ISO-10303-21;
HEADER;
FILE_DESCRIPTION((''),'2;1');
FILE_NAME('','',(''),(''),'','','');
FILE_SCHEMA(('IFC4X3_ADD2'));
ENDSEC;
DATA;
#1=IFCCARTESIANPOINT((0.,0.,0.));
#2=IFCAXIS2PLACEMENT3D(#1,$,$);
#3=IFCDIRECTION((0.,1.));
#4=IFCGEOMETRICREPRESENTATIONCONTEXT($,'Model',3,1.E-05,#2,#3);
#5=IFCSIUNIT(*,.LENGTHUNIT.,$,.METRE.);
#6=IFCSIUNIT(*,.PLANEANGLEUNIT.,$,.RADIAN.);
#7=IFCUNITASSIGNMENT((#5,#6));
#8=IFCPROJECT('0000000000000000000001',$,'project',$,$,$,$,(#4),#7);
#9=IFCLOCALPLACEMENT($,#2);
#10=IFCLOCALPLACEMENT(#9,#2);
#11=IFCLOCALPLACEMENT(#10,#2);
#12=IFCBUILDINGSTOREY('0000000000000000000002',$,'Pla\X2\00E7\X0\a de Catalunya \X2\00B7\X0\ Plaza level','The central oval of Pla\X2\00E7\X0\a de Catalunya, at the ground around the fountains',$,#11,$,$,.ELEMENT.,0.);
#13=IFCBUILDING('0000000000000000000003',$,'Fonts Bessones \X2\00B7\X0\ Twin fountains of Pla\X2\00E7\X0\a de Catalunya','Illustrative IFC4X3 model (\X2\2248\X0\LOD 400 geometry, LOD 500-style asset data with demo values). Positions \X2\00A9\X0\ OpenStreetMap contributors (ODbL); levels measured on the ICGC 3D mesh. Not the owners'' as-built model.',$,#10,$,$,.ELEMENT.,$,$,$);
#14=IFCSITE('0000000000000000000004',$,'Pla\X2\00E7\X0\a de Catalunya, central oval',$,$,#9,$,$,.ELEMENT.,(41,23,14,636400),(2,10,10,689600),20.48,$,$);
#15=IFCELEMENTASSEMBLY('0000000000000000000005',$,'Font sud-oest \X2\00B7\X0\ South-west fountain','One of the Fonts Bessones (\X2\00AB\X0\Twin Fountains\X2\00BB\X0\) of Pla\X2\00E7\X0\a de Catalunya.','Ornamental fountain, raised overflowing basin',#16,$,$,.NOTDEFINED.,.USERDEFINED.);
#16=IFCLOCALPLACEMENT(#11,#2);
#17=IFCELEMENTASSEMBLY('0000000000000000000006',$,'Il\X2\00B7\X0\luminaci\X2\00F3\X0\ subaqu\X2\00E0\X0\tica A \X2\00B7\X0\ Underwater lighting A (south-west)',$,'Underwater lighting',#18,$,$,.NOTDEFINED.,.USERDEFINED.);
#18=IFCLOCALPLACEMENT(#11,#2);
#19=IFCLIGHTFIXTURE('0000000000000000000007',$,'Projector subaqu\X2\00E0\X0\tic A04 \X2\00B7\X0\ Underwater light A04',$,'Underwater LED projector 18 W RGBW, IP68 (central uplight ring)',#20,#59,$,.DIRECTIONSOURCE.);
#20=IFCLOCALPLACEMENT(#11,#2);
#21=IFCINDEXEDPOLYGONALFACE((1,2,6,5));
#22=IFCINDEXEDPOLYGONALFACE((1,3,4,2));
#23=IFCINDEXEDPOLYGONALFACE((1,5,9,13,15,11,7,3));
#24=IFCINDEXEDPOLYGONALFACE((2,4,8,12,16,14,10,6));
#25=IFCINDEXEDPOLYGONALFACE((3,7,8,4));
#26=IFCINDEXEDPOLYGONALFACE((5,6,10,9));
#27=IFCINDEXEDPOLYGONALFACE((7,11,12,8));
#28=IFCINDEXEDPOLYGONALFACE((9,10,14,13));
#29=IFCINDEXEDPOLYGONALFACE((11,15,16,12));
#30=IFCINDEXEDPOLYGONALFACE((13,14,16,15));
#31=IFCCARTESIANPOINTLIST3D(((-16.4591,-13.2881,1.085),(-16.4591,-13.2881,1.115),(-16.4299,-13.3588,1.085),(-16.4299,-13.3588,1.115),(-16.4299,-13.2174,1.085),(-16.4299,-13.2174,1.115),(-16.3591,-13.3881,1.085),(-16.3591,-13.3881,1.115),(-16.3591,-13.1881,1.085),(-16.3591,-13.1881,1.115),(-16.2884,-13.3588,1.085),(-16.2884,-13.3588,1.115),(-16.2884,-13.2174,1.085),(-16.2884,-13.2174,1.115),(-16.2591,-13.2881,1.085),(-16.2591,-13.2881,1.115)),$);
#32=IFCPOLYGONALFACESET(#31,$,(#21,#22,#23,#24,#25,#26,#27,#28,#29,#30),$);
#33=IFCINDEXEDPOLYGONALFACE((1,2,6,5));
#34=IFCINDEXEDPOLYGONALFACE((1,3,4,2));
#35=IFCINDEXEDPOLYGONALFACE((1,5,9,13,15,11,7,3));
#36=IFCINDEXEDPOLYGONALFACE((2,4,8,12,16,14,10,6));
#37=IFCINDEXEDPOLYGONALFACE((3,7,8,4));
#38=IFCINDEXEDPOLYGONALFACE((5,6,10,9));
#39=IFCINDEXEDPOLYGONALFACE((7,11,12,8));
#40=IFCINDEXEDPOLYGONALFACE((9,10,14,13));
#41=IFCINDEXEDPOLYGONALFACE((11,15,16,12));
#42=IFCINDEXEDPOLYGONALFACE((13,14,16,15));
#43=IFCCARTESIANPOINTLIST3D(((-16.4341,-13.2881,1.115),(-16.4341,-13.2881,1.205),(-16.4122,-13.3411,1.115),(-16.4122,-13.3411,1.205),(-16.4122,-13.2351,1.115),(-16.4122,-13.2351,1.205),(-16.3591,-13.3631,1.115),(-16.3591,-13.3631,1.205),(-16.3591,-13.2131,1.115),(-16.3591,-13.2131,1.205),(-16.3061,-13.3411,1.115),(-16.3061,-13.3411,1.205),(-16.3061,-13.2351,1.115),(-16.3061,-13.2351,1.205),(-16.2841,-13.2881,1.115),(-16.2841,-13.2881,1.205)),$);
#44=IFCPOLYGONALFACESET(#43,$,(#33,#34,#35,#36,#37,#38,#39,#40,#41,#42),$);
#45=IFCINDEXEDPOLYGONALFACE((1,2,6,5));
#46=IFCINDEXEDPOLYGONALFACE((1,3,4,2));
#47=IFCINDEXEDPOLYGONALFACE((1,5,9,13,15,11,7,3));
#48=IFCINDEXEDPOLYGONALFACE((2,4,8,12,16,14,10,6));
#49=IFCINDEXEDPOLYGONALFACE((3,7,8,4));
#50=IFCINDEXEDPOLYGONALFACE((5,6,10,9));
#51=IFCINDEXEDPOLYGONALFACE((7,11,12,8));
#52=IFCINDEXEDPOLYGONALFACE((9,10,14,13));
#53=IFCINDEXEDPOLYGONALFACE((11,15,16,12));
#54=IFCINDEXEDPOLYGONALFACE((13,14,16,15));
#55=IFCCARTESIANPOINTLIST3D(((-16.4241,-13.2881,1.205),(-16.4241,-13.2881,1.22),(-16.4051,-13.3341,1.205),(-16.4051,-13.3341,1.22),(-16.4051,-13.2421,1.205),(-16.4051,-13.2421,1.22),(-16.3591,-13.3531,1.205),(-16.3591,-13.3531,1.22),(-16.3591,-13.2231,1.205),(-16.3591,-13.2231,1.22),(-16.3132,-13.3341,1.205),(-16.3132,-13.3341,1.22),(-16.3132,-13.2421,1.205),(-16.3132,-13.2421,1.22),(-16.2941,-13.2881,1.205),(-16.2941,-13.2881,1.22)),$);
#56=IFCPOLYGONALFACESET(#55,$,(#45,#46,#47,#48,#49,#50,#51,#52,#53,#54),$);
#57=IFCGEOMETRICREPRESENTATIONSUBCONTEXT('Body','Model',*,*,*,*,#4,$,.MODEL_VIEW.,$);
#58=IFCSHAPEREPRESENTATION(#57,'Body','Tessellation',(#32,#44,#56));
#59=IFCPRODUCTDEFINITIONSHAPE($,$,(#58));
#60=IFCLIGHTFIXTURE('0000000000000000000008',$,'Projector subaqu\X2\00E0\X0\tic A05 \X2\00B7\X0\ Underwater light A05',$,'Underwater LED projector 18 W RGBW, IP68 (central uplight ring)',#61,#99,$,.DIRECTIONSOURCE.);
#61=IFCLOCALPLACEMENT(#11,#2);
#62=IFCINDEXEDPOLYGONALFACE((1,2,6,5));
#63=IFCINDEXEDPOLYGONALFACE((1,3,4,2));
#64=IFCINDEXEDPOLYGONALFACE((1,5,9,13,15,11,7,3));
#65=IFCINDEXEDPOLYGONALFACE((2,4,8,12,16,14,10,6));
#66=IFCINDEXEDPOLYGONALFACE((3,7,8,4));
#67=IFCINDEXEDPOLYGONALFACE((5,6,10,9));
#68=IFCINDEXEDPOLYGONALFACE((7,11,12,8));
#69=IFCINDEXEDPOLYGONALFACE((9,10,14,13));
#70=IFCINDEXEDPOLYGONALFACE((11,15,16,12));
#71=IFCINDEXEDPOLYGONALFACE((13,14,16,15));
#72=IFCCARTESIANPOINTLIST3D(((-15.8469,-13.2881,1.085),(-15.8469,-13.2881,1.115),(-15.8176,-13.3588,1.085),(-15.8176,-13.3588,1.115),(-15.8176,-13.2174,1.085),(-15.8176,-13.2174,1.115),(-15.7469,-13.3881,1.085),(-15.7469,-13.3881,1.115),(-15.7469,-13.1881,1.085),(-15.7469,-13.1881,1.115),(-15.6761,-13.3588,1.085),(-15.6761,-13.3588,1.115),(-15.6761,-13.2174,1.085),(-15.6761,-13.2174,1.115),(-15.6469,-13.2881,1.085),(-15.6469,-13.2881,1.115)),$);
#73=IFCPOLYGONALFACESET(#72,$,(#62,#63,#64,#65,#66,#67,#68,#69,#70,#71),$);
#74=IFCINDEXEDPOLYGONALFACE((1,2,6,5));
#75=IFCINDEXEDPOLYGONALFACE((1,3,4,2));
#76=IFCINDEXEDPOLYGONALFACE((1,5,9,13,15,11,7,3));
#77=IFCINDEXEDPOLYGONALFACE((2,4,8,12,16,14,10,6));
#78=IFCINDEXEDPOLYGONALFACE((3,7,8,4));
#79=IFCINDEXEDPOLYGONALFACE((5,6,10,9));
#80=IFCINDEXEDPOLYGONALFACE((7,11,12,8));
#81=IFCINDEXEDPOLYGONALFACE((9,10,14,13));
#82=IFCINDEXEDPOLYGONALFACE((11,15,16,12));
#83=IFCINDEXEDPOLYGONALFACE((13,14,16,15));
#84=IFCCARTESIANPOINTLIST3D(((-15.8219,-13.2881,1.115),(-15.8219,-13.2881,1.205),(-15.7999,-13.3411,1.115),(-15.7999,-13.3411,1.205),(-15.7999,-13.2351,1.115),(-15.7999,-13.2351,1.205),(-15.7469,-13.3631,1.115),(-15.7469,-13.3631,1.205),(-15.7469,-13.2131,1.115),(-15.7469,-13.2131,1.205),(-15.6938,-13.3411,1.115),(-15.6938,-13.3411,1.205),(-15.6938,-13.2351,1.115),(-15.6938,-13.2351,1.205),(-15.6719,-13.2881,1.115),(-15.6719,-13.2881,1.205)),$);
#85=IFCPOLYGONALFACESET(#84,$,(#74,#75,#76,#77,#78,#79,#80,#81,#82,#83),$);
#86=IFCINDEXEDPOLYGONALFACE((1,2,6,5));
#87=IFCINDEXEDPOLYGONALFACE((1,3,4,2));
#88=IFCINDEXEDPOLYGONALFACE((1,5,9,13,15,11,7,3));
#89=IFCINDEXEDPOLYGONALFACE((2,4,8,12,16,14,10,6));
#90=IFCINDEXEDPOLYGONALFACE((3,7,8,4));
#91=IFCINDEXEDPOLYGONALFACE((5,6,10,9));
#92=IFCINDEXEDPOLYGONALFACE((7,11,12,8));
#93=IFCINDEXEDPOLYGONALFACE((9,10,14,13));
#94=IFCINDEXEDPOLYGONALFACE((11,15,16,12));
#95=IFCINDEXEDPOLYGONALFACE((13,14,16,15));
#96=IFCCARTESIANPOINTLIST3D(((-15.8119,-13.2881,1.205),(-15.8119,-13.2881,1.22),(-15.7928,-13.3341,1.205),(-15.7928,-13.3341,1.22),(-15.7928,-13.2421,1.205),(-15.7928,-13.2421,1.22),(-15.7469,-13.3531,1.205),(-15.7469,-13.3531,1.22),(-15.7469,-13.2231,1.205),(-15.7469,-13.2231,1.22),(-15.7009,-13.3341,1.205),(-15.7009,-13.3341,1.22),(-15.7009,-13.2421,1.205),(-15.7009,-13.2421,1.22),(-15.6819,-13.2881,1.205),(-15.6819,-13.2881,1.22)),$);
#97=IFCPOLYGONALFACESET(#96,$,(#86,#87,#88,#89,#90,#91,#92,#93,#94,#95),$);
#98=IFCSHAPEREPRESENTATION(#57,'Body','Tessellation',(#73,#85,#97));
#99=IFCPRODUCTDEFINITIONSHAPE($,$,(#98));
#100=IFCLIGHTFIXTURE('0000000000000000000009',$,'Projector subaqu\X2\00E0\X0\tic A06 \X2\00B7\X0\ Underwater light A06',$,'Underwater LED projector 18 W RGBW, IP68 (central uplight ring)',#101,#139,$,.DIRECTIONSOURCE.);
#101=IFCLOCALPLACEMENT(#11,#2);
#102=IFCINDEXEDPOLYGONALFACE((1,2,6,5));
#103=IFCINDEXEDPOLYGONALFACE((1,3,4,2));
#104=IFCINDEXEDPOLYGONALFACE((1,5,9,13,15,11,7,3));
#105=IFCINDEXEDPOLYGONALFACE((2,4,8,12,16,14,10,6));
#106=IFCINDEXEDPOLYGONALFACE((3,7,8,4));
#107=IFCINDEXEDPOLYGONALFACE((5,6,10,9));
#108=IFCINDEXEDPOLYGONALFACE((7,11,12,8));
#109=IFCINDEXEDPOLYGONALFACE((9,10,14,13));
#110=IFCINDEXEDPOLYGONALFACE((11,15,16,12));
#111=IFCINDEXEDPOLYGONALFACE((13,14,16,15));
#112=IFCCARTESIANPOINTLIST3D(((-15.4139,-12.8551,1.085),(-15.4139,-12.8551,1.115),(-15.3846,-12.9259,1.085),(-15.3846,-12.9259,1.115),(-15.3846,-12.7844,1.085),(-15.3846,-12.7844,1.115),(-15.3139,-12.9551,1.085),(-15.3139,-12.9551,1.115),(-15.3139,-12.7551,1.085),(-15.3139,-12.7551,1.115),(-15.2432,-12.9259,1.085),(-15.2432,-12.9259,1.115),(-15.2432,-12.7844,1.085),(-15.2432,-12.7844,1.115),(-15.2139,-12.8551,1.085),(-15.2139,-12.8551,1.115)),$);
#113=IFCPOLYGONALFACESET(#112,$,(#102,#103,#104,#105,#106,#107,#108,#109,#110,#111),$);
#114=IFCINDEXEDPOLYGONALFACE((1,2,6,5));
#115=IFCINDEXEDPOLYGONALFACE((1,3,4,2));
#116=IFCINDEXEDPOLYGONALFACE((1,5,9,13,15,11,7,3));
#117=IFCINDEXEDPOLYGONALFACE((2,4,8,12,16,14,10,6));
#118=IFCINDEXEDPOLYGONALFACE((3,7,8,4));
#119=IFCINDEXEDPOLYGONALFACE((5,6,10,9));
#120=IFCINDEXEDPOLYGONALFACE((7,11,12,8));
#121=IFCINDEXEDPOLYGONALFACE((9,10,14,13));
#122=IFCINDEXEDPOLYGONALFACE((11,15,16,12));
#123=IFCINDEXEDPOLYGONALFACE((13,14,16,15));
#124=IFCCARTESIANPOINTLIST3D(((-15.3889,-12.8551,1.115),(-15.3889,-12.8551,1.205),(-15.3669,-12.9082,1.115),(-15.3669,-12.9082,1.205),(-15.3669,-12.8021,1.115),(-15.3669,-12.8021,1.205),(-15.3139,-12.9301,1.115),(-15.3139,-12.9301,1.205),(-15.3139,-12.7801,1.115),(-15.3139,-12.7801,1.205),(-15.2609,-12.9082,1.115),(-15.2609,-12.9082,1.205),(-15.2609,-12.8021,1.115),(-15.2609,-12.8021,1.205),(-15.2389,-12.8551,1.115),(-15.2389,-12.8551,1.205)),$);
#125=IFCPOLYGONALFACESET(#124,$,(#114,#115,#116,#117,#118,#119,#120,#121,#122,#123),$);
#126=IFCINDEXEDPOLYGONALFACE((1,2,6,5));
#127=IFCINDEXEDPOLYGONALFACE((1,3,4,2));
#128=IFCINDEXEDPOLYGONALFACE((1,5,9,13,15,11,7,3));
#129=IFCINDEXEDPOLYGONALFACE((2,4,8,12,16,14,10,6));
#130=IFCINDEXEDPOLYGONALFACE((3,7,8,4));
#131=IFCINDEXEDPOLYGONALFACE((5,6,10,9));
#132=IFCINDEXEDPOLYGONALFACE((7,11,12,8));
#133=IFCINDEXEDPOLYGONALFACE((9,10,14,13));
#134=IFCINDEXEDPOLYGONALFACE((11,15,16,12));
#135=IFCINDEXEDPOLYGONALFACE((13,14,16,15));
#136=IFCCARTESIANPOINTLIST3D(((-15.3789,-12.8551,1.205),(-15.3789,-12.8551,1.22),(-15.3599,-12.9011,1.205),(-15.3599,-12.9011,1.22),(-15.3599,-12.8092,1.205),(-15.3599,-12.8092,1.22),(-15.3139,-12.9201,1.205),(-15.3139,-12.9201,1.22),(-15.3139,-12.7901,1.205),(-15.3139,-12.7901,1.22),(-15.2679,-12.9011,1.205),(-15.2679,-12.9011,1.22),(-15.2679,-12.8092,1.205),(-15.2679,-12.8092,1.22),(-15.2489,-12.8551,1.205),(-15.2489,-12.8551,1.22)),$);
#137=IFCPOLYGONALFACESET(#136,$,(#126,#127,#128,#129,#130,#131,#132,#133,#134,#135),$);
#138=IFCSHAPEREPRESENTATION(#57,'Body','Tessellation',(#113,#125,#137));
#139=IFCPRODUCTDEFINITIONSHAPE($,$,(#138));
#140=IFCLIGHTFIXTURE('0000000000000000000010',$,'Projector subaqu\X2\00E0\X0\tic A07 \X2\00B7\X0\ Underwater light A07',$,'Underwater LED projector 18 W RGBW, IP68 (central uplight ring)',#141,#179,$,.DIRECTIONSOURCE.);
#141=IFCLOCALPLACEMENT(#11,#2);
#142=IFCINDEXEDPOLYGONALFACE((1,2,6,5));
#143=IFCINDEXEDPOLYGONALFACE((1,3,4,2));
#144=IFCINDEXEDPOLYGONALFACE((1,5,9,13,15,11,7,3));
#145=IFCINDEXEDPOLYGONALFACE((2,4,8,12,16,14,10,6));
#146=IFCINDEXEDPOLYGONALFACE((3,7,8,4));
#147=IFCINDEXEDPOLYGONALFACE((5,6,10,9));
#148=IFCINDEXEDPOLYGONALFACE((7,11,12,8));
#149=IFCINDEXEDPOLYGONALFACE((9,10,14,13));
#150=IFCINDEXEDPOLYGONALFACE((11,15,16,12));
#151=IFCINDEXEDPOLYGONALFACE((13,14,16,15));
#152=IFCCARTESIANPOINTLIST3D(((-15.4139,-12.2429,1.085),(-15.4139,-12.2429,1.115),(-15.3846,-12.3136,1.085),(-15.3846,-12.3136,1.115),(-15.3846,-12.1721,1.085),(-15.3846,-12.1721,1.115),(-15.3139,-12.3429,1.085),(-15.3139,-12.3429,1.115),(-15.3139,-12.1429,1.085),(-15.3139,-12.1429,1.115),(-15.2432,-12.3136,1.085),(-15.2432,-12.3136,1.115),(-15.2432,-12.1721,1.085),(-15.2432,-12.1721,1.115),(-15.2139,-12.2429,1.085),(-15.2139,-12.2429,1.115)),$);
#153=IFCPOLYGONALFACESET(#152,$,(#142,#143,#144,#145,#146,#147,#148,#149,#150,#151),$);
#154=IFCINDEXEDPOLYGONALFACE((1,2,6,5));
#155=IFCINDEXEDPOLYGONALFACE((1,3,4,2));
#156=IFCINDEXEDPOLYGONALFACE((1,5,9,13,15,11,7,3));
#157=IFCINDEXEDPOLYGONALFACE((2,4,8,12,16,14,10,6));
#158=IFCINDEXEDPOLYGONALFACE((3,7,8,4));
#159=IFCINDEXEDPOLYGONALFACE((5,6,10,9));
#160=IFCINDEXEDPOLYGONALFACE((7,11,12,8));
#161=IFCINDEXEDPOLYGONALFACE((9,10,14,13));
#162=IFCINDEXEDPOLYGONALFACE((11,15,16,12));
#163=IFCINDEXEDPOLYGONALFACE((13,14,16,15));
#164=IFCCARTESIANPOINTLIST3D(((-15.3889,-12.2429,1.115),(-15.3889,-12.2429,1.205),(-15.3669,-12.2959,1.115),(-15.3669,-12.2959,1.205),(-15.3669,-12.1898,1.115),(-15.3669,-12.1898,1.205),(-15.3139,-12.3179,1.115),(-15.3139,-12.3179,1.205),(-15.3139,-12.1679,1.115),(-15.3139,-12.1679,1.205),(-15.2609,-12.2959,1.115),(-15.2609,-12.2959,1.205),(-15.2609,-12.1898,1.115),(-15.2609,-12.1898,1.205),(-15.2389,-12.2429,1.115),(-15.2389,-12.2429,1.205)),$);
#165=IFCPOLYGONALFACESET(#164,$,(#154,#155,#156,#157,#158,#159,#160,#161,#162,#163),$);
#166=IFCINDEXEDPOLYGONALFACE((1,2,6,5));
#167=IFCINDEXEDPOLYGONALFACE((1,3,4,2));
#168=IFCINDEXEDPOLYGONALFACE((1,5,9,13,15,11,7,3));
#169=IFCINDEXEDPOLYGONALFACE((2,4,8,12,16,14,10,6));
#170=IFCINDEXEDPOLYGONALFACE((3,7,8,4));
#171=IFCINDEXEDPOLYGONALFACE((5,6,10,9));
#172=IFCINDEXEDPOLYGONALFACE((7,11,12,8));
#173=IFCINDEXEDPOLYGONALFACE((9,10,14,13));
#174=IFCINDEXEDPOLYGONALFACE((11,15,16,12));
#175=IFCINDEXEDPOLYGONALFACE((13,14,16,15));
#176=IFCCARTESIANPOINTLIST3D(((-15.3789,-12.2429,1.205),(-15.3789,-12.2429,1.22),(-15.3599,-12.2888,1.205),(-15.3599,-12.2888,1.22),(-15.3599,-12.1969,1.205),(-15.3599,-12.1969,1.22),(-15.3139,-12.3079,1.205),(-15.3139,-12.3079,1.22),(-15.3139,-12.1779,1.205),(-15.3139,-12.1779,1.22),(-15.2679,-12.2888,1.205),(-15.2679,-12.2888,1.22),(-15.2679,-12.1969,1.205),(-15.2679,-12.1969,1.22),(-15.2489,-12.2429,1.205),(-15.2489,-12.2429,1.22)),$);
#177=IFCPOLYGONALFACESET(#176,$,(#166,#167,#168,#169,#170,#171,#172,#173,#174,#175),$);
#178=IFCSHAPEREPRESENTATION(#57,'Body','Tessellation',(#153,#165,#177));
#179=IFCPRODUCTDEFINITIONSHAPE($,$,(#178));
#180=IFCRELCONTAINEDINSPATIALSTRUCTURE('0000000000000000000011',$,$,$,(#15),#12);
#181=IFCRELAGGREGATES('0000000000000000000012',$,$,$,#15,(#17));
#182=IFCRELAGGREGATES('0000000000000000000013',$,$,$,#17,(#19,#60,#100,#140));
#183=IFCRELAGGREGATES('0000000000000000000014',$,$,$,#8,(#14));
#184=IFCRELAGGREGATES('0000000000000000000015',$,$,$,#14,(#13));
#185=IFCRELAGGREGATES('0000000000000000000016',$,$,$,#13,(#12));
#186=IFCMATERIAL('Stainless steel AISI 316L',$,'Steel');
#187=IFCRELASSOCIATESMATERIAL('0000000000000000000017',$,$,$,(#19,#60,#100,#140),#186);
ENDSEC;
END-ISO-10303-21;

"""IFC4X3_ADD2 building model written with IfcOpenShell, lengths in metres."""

from ifc_helpers import new_model, si_unit, direction, frame, origin, place, context, subcontext, project, spatial, polyline, outline, extrude, material, element, aggregate, save


model = new_model("IFC4X3_ADD2")

# Units and contexts
model_context = context("Model", 3, precision=1e-05, world=origin(), true_north=direction((0.0, 1.0)))
body_context = subcontext(model_context, "Body", "Model", "MODEL_VIEW")
ifc_project = project(units=[si_unit("LENGTHUNIT", "METRE"), si_unit("PLANEANGLEUNIT", "RADIAN")], contexts=[model_context])

# Site, building, storey
site_placement = place(None, origin())
site = spatial("IfcSite", under=ifc_project, at=site_placement, Name="Plaça de Catalunya, central oval", CompositionType="ELEMENT", RefLatitude=(41, 23, 14, 636400), RefLongitude=(2, 10, 10, 689600), RefElevation=20.48)
building_placement = place(site_placement, origin())
building = spatial("IfcBuilding", under=site, at=building_placement, Name="Fonts Bessones · Twin fountains of Plaça de Catalunya", Description="Illustrative IFC4X3 model (≈LOD 400 geometry, LOD 500-style asset data with demo values). Positions © OpenStreetMap contributors (ODbL); levels measured on the ICGC 3D mesh. Not the owners' as-built model.", CompositionType="ELEMENT")
storey_placement = place(building_placement, origin())
storey = spatial("IfcBuildingStorey", under=building, at=storey_placement, Name="Plaça de Catalunya · Plaza level", Description="The central oval of Plaça de Catalunya, at the ground around the fountains", CompositionType="ELEMENT", Elevation=0.0)

# Element assemblies, light fixtures
assembly_1_placement = place(building_placement, origin())
assembly_1 = element("IfcElementAssembly", 1, at=assembly_1_placement, inside=storey, Name="Font sud-oest · South-west fountain", Description="One of the Fonts Bessones («Twin Fountains») of Plaça de Catalunya.", ObjectType="Ornamental fountain, raised overflowing basin", AssemblyPlace="NOTDEFINED", PredefinedType="USERDEFINED")
assembly_2_placement = place(building_placement, origin())
assembly_2 = element("IfcElementAssembly", 2, at=assembly_2_placement, Name="Il·luminació subaquàtica A · Underwater lighting A (south-west)", ObjectType="Underwater lighting", AssemblyPlace="NOTDEFINED", PredefinedType="USERDEFINED")
aggregate(assembly_1, [assembly_2])
ifc_material_1 = material(Name="Stainless steel AISI 316L", Category="Steel")
light_fixture_1_placement = place(building_placement, origin())
light_fixture_1 = element("IfcLightFixture", 3, at=light_fixture_1_placement, material=ifc_material_1, Name="Projector subaquàtic A04 · Underwater light A04", ObjectType="Underwater LED projector 18 W RGBW, IP68 (central uplight ring)", PredefinedType="DIRECTIONSOURCE", context=body_context, shape_type="SweptSolid", body=[
    extrude(outline(polyline([(-16.2591, -13.2881), (-16.2884, -13.2174), (-16.3591, -13.1881), (-16.4299, -13.2174), (-16.4591, -13.2881), (-16.4299, -13.3588), (-16.3591, -13.3881), (-16.2884, -13.3588), (-16.2591, -13.2881)])), frame((0.0, 0.0, 1.085)), (0.0, 0.0, 1.0), 0.03),
    extrude(outline(polyline([(-16.2841, -13.2881), (-16.3061, -13.2351), (-16.3591, -13.2131), (-16.4122, -13.2351), (-16.4341, -13.2881), (-16.4122, -13.3411), (-16.3591, -13.3631), (-16.3061, -13.3411), (-16.2841, -13.2881)])), frame((0.0, 0.0, 1.115)), (0.0, 0.0, 1.0), 0.09),
    extrude(outline(polyline([(-16.2941, -13.2881), (-16.3132, -13.2421), (-16.3591, -13.2231), (-16.4051, -13.2421), (-16.4241, -13.2881), (-16.4051, -13.3341), (-16.3591, -13.3531), (-16.3132, -13.3341), (-16.2941, -13.2881)])), frame((0.0, 0.0, 1.205)), (0.0, 0.0, 1.0), 0.015),
])
light_fixture_2_placement = place(building_placement, origin())
light_fixture_2 = element("IfcLightFixture", 4, at=light_fixture_2_placement, material=ifc_material_1, Name="Projector subaquàtic A05 · Underwater light A05", ObjectType="Underwater LED projector 18 W RGBW, IP68 (central uplight ring)", PredefinedType="DIRECTIONSOURCE", context=body_context, shape_type="SweptSolid", body=[
    extrude(outline(polyline([(-15.6469, -13.2881), (-15.6761, -13.2174), (-15.7469, -13.1881), (-15.8176, -13.2174), (-15.8469, -13.2881), (-15.8176, -13.3588), (-15.7469, -13.3881), (-15.6761, -13.3588), (-15.6469, -13.2881)])), frame((0.0, 0.0, 1.085)), (0.0, 0.0, 1.0), 0.03),
    extrude(outline(polyline([(-15.6719, -13.2881), (-15.6938, -13.2351), (-15.7469, -13.2131), (-15.7999, -13.2351), (-15.8219, -13.2881), (-15.7999, -13.3411), (-15.7469, -13.3631), (-15.6938, -13.3411), (-15.6719, -13.2881)])), frame((0.0, 0.0, 1.115)), (0.0, 0.0, 1.0), 0.09),
    extrude(outline(polyline([(-15.6819, -13.2881), (-15.7009, -13.2421), (-15.7469, -13.2231), (-15.7928, -13.2421), (-15.8119, -13.2881), (-15.7928, -13.3341), (-15.7469, -13.3531), (-15.7009, -13.3341), (-15.6819, -13.2881)])), frame((0.0, 0.0, 1.205)), (0.0, 0.0, 1.0), 0.015),
])
light_fixture_3_placement = place(building_placement, origin())
light_fixture_3 = element("IfcLightFixture", 5, at=light_fixture_3_placement, material=ifc_material_1, Name="Projector subaquàtic A06 · Underwater light A06", ObjectType="Underwater LED projector 18 W RGBW, IP68 (central uplight ring)", PredefinedType="DIRECTIONSOURCE", context=body_context, shape_type="SweptSolid", body=[
    extrude(outline(polyline([(-15.2139, -12.8551), (-15.2432, -12.7844), (-15.3139, -12.7551), (-15.3846, -12.7844), (-15.4139, -12.8551), (-15.3846, -12.9259), (-15.3139, -12.9551), (-15.2432, -12.9259), (-15.2139, -12.8551)])), frame((0.0, 0.0, 1.085)), (0.0, 0.0, 1.0), 0.03),
    extrude(outline(polyline([(-15.2389, -12.8551), (-15.2609, -12.8021), (-15.3139, -12.7801), (-15.3669, -12.8021), (-15.3889, -12.8551), (-15.3669, -12.9082), (-15.3139, -12.9301), (-15.2609, -12.9082), (-15.2389, -12.8551)])), frame((0.0, 0.0, 1.115)), (0.0, 0.0, 1.0), 0.09),
    extrude(outline(polyline([(-15.2489, -12.8551), (-15.2679, -12.8092), (-15.3139, -12.7901), (-15.3599, -12.8092), (-15.3789, -12.8551), (-15.3599, -12.9011), (-15.3139, -12.9201), (-15.2679, -12.9011), (-15.2489, -12.8551)])), frame((0.0, 0.0, 1.205)), (0.0, 0.0, 1.0), 0.015),
])
light_fixture_4_placement = place(building_placement, origin())
light_fixture_4 = element("IfcLightFixture", 6, at=light_fixture_4_placement, material=ifc_material_1, Name="Projector subaquàtic A07 · Underwater light A07", ObjectType="Underwater LED projector 18 W RGBW, IP68 (central uplight ring)", PredefinedType="DIRECTIONSOURCE", context=body_context, shape_type="SweptSolid", body=[
    extrude(outline(polyline([(-15.2139, -12.2429), (-15.2432, -12.1721), (-15.3139, -12.1429), (-15.3846, -12.1721), (-15.4139, -12.2429), (-15.3846, -12.3136), (-15.3139, -12.3429), (-15.2432, -12.3136), (-15.2139, -12.2429)])), frame((0.0, 0.0, 1.085)), (0.0, 0.0, 1.0), 0.03),
    extrude(outline(polyline([(-15.2389, -12.2429), (-15.2609, -12.1898), (-15.3139, -12.1679), (-15.3669, -12.1898), (-15.3889, -12.2429), (-15.3669, -12.2959), (-15.3139, -12.3179), (-15.2609, -12.2959), (-15.2389, -12.2429)])), frame((0.0, 0.0, 1.115)), (0.0, 0.0, 1.0), 0.09),
    extrude(outline(polyline([(-15.2489, -12.2429), (-15.2679, -12.1969), (-15.3139, -12.1779), (-15.3599, -12.1969), (-15.3789, -12.2429), (-15.3599, -12.2888), (-15.3139, -12.3079), (-15.2679, -12.2888), (-15.2489, -12.2429)])), frame((0.0, 0.0, 1.205)), (0.0, 0.0, 1.0), 0.015),
])
aggregate(assembly_2, [light_fixture_1, light_fixture_2, light_fixture_3, light_fixture_4])

save(model, "model.ifc")
